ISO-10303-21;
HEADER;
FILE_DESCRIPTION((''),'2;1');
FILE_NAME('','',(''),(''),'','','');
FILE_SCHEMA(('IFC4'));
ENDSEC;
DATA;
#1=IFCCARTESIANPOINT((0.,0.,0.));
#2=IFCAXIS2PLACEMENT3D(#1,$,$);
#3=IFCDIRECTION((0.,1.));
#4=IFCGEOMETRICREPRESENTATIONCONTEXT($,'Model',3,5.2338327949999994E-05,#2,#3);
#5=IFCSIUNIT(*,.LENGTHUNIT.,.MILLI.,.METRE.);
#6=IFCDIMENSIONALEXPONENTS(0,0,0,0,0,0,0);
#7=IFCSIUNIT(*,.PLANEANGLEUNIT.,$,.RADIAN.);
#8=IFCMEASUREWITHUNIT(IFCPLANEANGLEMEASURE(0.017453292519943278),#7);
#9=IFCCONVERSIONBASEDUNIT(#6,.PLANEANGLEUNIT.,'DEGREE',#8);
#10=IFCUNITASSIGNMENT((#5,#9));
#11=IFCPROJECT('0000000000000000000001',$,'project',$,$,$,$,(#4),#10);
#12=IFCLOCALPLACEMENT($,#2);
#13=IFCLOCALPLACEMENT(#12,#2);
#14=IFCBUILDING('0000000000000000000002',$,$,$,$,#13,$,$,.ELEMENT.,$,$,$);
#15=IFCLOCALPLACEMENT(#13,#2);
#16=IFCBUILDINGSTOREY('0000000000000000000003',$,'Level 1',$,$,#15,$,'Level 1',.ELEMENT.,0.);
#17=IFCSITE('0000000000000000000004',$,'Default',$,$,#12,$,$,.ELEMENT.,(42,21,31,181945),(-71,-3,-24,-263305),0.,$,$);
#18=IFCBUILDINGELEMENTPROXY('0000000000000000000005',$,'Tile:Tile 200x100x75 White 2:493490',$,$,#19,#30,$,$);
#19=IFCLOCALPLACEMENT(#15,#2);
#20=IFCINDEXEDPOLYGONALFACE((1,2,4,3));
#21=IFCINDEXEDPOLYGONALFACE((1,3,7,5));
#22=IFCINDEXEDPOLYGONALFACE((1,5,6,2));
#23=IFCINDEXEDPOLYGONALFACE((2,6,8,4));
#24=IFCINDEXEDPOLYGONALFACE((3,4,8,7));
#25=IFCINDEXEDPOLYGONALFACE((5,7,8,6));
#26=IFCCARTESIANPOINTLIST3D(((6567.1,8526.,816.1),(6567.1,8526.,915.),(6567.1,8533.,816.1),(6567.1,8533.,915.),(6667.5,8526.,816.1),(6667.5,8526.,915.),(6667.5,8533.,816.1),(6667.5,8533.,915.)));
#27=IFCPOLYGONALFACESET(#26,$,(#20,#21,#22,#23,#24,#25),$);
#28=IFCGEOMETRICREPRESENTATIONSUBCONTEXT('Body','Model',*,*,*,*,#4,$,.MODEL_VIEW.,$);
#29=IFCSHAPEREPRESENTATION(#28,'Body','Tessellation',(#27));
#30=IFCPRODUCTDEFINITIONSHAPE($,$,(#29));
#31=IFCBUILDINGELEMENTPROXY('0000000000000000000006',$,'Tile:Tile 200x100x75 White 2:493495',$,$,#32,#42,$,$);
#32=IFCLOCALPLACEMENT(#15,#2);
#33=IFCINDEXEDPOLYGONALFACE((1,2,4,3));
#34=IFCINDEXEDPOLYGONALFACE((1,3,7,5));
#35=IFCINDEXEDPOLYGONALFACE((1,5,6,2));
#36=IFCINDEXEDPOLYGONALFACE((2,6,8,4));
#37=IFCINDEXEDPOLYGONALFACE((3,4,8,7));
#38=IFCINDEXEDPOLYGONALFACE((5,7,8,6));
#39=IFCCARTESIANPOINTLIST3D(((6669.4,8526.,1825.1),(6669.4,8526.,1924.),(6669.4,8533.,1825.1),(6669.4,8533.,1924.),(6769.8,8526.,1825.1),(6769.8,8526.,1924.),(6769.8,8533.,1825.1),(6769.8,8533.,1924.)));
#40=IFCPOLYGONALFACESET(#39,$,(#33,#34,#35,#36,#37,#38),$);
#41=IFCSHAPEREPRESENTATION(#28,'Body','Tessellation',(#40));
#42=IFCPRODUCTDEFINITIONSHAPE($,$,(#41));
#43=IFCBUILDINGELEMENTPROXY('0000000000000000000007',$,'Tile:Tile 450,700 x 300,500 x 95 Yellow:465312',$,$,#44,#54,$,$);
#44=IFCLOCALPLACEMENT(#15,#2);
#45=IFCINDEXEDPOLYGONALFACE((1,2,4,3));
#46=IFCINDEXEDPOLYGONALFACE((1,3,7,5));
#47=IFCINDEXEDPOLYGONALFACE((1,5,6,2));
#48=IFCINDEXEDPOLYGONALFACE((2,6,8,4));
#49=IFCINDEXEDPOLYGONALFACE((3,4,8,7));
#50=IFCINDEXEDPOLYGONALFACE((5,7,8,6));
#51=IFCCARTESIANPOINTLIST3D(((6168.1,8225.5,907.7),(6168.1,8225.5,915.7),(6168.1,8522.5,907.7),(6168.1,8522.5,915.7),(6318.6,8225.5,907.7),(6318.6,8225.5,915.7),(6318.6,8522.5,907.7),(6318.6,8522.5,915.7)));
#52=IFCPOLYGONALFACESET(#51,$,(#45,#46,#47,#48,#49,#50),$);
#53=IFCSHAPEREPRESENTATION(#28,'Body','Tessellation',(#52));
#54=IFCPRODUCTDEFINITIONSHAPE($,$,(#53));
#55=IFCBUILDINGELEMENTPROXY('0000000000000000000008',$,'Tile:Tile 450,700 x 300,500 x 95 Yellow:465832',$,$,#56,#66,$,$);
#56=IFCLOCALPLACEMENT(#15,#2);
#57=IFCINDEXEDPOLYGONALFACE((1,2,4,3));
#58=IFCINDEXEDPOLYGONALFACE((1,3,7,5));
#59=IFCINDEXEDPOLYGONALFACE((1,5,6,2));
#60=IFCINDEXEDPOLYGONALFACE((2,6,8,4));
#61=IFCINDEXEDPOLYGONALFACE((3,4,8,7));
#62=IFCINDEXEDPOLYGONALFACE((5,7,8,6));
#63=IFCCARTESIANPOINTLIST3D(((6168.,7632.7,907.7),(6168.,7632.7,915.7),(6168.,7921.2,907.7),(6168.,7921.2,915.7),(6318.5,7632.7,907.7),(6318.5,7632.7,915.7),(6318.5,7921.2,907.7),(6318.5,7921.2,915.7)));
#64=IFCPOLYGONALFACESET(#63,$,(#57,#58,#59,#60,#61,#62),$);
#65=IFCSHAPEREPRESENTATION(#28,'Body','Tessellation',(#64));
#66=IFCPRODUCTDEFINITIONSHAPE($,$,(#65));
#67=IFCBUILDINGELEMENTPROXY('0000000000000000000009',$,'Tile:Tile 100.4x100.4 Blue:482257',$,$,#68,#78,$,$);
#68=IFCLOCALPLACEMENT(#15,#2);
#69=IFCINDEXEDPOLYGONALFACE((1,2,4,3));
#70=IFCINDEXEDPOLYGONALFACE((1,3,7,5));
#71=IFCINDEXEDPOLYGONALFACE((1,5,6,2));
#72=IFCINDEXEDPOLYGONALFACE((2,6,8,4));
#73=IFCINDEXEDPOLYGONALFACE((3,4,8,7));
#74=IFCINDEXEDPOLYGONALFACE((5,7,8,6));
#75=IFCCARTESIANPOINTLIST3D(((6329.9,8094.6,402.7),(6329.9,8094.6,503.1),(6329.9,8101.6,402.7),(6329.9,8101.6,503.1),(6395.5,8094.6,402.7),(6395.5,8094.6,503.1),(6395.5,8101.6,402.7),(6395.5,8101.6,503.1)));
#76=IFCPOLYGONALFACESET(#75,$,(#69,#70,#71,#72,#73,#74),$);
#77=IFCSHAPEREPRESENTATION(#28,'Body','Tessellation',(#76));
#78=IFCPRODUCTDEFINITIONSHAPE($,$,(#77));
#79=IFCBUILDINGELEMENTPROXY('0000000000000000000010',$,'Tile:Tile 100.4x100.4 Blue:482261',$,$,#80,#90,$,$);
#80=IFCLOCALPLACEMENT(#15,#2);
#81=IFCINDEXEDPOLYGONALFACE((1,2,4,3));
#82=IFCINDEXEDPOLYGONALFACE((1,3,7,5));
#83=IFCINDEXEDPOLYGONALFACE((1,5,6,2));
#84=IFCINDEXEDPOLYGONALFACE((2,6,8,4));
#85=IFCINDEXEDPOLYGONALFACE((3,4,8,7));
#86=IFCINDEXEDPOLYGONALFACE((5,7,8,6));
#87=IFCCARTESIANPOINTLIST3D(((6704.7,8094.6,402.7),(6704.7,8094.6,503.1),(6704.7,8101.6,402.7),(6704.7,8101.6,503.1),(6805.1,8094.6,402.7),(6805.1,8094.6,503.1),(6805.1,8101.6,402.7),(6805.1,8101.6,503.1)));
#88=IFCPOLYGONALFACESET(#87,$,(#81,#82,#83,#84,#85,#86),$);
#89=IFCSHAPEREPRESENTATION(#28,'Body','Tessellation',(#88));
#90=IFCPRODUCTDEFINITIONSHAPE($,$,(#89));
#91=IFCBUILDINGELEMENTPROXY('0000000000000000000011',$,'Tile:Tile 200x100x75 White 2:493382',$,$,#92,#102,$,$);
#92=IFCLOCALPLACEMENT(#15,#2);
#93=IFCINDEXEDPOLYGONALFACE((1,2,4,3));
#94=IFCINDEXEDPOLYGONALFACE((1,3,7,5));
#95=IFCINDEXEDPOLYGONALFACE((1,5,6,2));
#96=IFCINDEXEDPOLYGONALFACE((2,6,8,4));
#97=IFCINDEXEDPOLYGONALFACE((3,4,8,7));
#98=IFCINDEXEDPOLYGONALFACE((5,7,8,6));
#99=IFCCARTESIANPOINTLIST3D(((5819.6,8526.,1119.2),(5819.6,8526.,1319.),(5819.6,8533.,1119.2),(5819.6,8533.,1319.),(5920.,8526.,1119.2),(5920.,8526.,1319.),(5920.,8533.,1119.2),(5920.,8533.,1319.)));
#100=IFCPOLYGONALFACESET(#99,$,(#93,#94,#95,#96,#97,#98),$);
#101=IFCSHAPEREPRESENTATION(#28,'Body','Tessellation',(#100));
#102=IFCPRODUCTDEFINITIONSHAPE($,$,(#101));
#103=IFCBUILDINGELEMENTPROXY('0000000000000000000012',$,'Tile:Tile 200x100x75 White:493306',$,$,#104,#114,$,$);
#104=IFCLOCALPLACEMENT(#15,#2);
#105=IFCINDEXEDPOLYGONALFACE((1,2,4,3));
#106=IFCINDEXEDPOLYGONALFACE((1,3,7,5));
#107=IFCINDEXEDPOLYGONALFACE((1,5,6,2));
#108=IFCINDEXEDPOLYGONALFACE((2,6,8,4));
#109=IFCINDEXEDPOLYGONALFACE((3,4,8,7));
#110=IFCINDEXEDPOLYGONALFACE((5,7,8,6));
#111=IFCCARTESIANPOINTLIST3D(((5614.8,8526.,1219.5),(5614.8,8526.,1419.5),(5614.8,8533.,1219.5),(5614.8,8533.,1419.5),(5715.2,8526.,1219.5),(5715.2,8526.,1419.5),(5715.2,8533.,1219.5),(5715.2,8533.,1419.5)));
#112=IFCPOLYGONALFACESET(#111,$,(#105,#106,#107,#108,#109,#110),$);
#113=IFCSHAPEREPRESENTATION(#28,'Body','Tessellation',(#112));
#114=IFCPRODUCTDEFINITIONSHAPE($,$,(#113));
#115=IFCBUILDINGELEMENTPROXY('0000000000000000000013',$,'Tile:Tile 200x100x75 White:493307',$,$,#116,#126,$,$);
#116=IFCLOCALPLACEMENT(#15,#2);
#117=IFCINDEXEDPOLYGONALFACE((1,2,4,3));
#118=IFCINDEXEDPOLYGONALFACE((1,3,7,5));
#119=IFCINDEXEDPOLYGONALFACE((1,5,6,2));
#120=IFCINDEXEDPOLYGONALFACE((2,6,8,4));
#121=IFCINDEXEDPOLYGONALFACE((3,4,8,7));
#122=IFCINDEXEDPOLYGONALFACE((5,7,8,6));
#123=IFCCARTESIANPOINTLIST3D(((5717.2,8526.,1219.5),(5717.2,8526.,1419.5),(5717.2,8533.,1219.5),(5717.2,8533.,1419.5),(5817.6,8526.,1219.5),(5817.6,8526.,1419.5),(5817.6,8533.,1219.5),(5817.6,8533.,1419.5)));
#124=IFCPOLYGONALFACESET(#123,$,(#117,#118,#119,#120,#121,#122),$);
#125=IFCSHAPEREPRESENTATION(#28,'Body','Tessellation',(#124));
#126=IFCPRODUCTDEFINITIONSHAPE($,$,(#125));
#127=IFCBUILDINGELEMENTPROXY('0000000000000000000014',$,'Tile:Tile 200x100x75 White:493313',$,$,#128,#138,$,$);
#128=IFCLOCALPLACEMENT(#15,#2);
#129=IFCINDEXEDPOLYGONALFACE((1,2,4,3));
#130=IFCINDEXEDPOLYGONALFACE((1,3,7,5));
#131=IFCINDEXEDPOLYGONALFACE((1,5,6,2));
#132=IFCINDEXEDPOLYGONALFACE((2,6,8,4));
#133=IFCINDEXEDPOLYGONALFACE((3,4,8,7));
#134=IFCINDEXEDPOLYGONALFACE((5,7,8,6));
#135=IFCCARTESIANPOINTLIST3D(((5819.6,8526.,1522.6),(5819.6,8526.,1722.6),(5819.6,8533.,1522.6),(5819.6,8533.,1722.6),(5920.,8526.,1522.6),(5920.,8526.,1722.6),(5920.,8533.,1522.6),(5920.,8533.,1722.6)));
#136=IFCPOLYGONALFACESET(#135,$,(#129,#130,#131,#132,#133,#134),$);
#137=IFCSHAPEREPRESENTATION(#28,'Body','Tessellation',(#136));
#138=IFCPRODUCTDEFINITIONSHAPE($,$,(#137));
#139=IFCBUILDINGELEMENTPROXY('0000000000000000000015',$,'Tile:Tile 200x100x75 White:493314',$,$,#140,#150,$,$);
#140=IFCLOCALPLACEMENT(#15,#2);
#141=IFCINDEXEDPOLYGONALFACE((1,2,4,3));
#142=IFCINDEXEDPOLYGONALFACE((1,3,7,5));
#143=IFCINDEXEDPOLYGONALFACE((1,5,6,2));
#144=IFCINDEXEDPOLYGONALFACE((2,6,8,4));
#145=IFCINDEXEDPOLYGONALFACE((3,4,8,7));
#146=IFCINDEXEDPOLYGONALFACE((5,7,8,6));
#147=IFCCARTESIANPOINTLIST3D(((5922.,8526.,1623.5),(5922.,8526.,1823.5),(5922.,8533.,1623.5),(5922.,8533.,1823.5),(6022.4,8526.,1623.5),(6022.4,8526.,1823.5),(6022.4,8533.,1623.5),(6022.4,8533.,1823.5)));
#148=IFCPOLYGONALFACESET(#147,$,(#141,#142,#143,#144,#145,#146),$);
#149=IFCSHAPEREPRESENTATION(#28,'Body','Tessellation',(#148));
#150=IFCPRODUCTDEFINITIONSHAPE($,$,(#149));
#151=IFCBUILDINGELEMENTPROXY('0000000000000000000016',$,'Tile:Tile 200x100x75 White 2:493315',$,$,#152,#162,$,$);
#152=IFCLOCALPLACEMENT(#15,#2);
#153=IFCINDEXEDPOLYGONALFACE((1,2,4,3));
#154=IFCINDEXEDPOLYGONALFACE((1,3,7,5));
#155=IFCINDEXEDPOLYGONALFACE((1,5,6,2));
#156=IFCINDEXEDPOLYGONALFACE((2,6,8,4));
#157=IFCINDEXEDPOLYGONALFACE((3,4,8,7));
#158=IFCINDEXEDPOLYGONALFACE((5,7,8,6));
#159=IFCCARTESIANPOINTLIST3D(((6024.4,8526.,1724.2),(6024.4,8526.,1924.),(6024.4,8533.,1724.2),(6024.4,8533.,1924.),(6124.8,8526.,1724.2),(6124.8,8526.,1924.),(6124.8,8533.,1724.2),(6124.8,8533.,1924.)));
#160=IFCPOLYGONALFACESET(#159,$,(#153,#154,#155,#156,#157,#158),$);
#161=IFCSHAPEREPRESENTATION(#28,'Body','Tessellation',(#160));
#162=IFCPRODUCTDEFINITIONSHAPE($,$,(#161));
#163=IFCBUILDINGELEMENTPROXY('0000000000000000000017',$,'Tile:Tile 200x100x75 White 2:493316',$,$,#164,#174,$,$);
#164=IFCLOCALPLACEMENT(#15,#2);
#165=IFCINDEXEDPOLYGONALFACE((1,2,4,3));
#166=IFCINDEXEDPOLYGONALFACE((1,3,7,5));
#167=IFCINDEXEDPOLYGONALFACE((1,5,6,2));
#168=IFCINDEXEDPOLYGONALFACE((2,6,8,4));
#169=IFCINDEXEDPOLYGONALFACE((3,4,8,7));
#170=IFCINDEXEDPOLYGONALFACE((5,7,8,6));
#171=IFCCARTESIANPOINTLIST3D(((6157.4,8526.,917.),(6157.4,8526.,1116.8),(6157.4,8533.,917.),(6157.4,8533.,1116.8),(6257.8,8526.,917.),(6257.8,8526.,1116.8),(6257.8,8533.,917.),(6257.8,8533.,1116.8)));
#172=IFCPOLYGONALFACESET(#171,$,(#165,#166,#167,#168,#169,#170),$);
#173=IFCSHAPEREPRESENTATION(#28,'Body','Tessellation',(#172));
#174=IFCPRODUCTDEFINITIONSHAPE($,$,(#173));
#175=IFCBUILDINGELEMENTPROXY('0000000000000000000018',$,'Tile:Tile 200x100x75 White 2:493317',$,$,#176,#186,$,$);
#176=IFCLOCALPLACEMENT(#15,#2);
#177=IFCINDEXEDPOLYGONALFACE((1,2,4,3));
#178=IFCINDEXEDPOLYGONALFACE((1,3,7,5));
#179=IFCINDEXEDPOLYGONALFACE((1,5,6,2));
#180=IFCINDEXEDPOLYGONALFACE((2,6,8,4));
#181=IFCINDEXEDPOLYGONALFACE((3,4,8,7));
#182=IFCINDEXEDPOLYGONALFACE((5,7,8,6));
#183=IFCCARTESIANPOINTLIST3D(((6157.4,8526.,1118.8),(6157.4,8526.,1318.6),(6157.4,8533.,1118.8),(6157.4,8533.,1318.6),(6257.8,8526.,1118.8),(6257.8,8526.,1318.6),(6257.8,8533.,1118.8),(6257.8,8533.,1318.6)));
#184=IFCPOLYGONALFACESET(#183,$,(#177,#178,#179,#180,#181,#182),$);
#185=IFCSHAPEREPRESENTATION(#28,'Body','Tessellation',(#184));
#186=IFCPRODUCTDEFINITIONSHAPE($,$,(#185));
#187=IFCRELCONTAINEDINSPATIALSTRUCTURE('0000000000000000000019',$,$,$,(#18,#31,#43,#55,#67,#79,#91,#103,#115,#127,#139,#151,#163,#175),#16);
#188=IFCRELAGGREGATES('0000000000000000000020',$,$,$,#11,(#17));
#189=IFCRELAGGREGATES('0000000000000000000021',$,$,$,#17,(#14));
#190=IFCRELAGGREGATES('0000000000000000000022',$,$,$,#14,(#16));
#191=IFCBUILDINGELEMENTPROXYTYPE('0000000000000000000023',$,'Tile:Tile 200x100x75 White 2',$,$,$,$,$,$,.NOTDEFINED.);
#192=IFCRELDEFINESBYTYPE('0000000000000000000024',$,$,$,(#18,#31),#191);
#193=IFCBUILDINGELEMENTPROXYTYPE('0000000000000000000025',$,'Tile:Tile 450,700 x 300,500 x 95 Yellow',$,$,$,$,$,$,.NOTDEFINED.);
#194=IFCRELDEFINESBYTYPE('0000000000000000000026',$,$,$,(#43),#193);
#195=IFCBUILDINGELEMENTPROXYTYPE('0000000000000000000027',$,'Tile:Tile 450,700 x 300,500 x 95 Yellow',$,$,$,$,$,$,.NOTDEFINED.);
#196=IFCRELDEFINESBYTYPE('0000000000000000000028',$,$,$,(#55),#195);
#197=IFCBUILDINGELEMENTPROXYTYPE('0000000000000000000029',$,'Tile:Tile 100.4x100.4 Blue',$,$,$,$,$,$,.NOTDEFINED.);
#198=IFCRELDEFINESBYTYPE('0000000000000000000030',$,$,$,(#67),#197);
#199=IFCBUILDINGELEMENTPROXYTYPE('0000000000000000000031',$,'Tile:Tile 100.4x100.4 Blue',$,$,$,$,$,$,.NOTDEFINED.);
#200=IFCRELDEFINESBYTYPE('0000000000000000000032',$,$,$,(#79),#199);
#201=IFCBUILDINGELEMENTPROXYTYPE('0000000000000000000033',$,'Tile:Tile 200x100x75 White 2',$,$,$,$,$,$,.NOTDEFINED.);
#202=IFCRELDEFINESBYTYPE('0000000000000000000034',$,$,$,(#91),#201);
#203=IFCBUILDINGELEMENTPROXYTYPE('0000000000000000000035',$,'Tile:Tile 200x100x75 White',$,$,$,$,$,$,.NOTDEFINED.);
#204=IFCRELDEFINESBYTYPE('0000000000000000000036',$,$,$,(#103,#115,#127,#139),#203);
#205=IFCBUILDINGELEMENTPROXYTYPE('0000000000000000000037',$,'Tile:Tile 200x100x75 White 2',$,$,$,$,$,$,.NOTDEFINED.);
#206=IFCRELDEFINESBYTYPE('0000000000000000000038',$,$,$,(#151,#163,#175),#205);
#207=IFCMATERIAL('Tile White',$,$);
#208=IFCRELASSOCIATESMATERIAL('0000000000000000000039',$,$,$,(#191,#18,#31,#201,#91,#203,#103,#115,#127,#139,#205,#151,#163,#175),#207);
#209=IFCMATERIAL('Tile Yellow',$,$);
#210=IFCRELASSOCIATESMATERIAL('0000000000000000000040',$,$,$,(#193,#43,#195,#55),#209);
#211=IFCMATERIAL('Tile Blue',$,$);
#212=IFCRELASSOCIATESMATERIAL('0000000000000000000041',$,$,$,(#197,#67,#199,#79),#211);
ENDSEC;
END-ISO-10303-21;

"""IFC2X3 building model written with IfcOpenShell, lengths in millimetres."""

from ifc_helpers import new_model, entity, si_unit, converted_unit, direction, frame, frame_2d, origin, origin_2d_with_axis, place, context, subcontext, project, spatial, rectangle, extrude, source, transform, mapped, material, type_object, type_shapes, element, save


model = new_model("IFC2X3")

# Units and contexts
model_context = context("Model", 3, precision=5.2338327949999994e-05, world=origin(), true_north=direction((0.0, 1.0)))
body_context = subcontext(model_context, "Body", "Model", "MODEL_VIEW")
ifc_project = project(units=[si_unit("LENGTHUNIT", "METRE", prefix="MILLI"), converted_unit("PLANEANGLEUNIT", "DEGREE", entity("IfcPlaneAngleMeasure", 0.017453292519943278), si_unit("PLANEANGLEUNIT", "RADIAN"), dimensions=[0, 0, 0, 0, 0, 0, 0])], contexts=[model_context])

# Site, building, storey
site_placement = place(None, origin())
site = spatial("IfcSite", under=ifc_project, at=site_placement, Name="Default", CompositionType="ELEMENT", RefLatitude=(42, 21, 31, 181945), RefLongitude=(-71, -3, -24, -263305), RefElevation=0.0)
building_placement = place(site_placement, origin())
building = spatial("IfcBuilding", under=site, at=building_placement, CompositionType="ELEMENT")
storey_placement = place(building_placement, origin())
storey = spatial("IfcBuildingStorey", under=building, at=storey_placement, Name="Level 1", LongName="Level 1", CompositionType="ELEMENT", Elevation=0.0)

# Building element proxies
ifc_material_1 = material(Name="Tile White")
building_element_proxy_type_1 = type_object("IfcBuildingElementProxyType", Name="Tile:Tile 200x100x75 White 2", PredefinedType="NOTDEFINED", material=ifc_material_1)
shared_shape_1 = source(origin(), body_context, "Body", "SweptSolid", [
    extrude(rectangle(XDim=98.9, YDim=100.4, at=origin_2d_with_axis()), frame((-50.2, -49.5, 0.0), z_axis=(0.0, 0.0, 1.0), x_axis=(0.0, -1.0, 0.0)), (0.0, 0.0, 1.0), 7.0),
])
type_shapes(building_element_proxy_type_1, [shared_shape_1])
for number, where, z_axis, x_axis, name in (
    (1, (6667.5, 8533.0, 915.0), (0.0, -1.0, 0.0), (1.0, 0.0, 0.0), "Tile:Tile 200x100x75 White 2:493490"),
    (2, (6769.8, 8533.0, 1924.0), (0.0, -1.0, 0.0), (1.0, 0.0, 0.0), "Tile:Tile 200x100x75 White 2:493495"),
):
    element("IfcBuildingElementProxy", number, at=place(storey_placement, frame(where, z_axis=z_axis, x_axis=x_axis)), inside=storey, type_object=building_element_proxy_type_1, material=ifc_material_1, Name=name, context=body_context, shape_type="MappedRepresentation", body=[
        mapped(shared_shape_1, transform((0.0, 0.0, 0.0), scale=1.0)),
    ])
ifc_material_2 = material(Name="Tile Yellow")
building_element_proxy_type_2 = type_object("IfcBuildingElementProxyType", Name="Tile:Tile 450,700 x 300,500 x 95 Yellow", PredefinedType="NOTDEFINED", material=ifc_material_2)
shared_shape_2 = source(origin(), body_context, "Body", "SweptSolid", [
    extrude(rectangle(XDim=150.5, YDim=297.0, at=frame_2d((0.0, 0.0), x_axis=(1.0, 0.0))), frame((-75.2, -148.5, 0.0), z_axis=(0.0, 0.0, 1.0), x_axis=(-1.0, 0.0, 0.0)), (0.0, 0.0, 1.0), 8.0),
])
type_shapes(building_element_proxy_type_2, [shared_shape_2])
proxy_1_placement = place(storey_placement, frame((6318.6, 8522.5, 907.7)))
element("IfcBuildingElementProxy", 3, at=proxy_1_placement, inside=storey, type_object=building_element_proxy_type_2, material=ifc_material_2, Name="Tile:Tile 450,700 x 300,500 x 95 Yellow:465312", context=body_context, shape_type="MappedRepresentation", body=[
    mapped(shared_shape_2, transform((0.0, 0.0, 0.0), scale=1.0)),
])
building_element_proxy_type_3 = type_object("IfcBuildingElementProxyType", Name="Tile:Tile 450,700 x 300,500 x 95 Yellow", PredefinedType="NOTDEFINED", material=ifc_material_2)
shared_shape_3 = source(origin(), body_context, "Body", "SweptSolid", [
    extrude(rectangle(XDim=150.5, YDim=288.5, at=origin_2d_with_axis()), frame((-75.2, -144.3, 0.0), z_axis=(0.0, 0.0, 1.0), x_axis=(-1.0, 0.0, 0.0)), (0.0, 0.0, 1.0), 8.0),
])
type_shapes(building_element_proxy_type_3, [shared_shape_3])
proxy_2_placement = place(storey_placement, frame((6318.5, 7921.2, 907.7)))
element("IfcBuildingElementProxy", 4, at=proxy_2_placement, inside=storey, type_object=building_element_proxy_type_3, material=ifc_material_2, Name="Tile:Tile 450,700 x 300,500 x 95 Yellow:465832", context=body_context, shape_type="MappedRepresentation", body=[
    mapped(shared_shape_3, transform((0.0, 0.0, 0.0), scale=1.0)),
])
ifc_material_3 = material(Name="Tile Blue")
building_element_proxy_type_4 = type_object("IfcBuildingElementProxyType", Name="Tile:Tile 100.4x100.4 Blue", PredefinedType="NOTDEFINED", material=ifc_material_3)
shared_shape_4 = source(origin(), body_context, "Body", "SweptSolid", [
    extrude(rectangle(XDim=65.6, YDim=100.4, at=frame_2d((0.0, 0.0), x_axis=(1.0, 0.0))), frame((-32.8, -50.2, 0.0), z_axis=(0.0, 0.0, 1.0), x_axis=(-1.0, 0.0, 0.0)), (0.0, 0.0, 1.0), 7.0),
])
type_shapes(building_element_proxy_type_4, [shared_shape_4])
proxy_3_placement = place(storey_placement, frame((6329.9, 8101.6, 402.7), z_axis=(0.0, -1.0, 0.0), x_axis=(-1.0, 0.0, 0.0)))
element("IfcBuildingElementProxy", 5, at=proxy_3_placement, inside=storey, type_object=building_element_proxy_type_4, material=ifc_material_3, Name="Tile:Tile 100.4x100.4 Blue:482257", context=body_context, shape_type="MappedRepresentation", body=[
    mapped(shared_shape_4, transform((0.0, 0.0, 0.0), scale=1.0)),
])
building_element_proxy_type_5 = type_object("IfcBuildingElementProxyType", Name="Tile:Tile 100.4x100.4 Blue", PredefinedType="NOTDEFINED", material=ifc_material_3)
shared_shape_5 = source(origin(), body_context, "Body", "SweptSolid", [
    extrude(rectangle(XDim=100.4, YDim=100.4, at=origin_2d_with_axis()), frame((-50.2, -50.2, 0.0), z_axis=(0.0, 0.0, 1.0), x_axis=(0.0, -1.0, 0.0)), (0.0, 0.0, 1.0), 7.0),
])
type_shapes(building_element_proxy_type_5, [shared_shape_5])
proxy_4_placement = place(storey_placement, frame((6704.7, 8101.6, 402.7), z_axis=(0.0, -1.0, 0.0), x_axis=(-1.0, 0.0, 0.0)))
element("IfcBuildingElementProxy", 6, at=proxy_4_placement, inside=storey, type_object=building_element_proxy_type_5, material=ifc_material_3, Name="Tile:Tile 100.4x100.4 Blue:482261", context=body_context, shape_type="MappedRepresentation", body=[
    mapped(shared_shape_5, transform((0.0, 0.0, 0.0), scale=1.0)),
])
building_element_proxy_type_6 = type_object("IfcBuildingElementProxyType", Name="Tile:Tile 200x100x75 White 2", PredefinedType="NOTDEFINED", material=ifc_material_1)
shared_shape_6 = source(origin(), body_context, "Body", "SweptSolid", [
    extrude(rectangle(XDim=199.8, YDim=100.4, at=frame_2d((0.0, 0.0), x_axis=(1.0, 0.0))), frame((-50.2, -99.9, 0.0), z_axis=(0.0, 0.0, 1.0), x_axis=(0.0, -1.0, 0.0)), (0.0, 0.0, 1.0), 7.0),
])
type_shapes(building_element_proxy_type_6, [shared_shape_6])
proxy_5_placement = place(storey_placement, frame((5920.0, 8533.0, 1319.0), z_axis=(0.0, -1.0, 0.0), x_axis=(1.0, 0.0, 0.0)))
element("IfcBuildingElementProxy", 7, at=proxy_5_placement, inside=storey, type_object=building_element_proxy_type_6, material=ifc_material_1, Name="Tile:Tile 200x100x75 White 2:493382", context=body_context, shape_type="MappedRepresentation", body=[
    mapped(shared_shape_6, transform((0.0, 0.0, 0.0), scale=1.0)),
])
building_element_proxy_type_7 = type_object("IfcBuildingElementProxyType", Name="Tile:Tile 200x100x75 White", PredefinedType="NOTDEFINED", material=ifc_material_1)
shared_shape_7 = source(origin(), body_context, "Body", "SweptSolid", [
    extrude(rectangle(XDim=200.0, YDim=100.4, at=frame_2d((0.0, 0.0), x_axis=(1.0, 0.0))), frame((-50.2, -100.0, 0.0), z_axis=(0.0, 0.0, 1.0), x_axis=(0.0, -1.0, 0.0)), (0.0, 0.0, 1.0), 7.0),
])
type_shapes(building_element_proxy_type_7, [shared_shape_7])
for number, where, z_axis, x_axis, name in (
    (8, (5715.2, 8533.0, 1419.5), (0.0, -1.0, 0.0), (1.0, 0.0, 0.0), "Tile:Tile 200x100x75 White:493306"),
    (9, (5817.6, 8533.0, 1419.5), (0.0, -1.0, 0.0), (1.0, 0.0, 0.0), "Tile:Tile 200x100x75 White:493307"),
    (10, (5819.6, 8533.0, 1522.6), (0.0, -1.0, 0.0), (-1.0, 0.0, 0.0), "Tile:Tile 200x100x75 White:493313"),
    (11, (5922.0, 8533.0, 1623.5), (0.0, -1.0, 0.0), (-1.0, 0.0, 0.0), "Tile:Tile 200x100x75 White:493314"),
):
    element("IfcBuildingElementProxy", number, at=place(storey_placement, frame(where, z_axis=z_axis, x_axis=x_axis)), inside=storey, type_object=building_element_proxy_type_7, material=ifc_material_1, Name=name, context=body_context, shape_type="MappedRepresentation", body=[
        mapped(shared_shape_7, transform((0.0, 0.0, 0.0), scale=1.0)),
    ])
building_element_proxy_type_8 = type_object("IfcBuildingElementProxyType", Name="Tile:Tile 200x100x75 White 2", PredefinedType="NOTDEFINED", material=ifc_material_1)
shared_shape_8 = source(origin(), body_context, "Body", "SweptSolid", [
    extrude(rectangle(XDim=199.8, YDim=100.4, at=frame_2d((0.0, 0.0), x_axis=(1.0, 0.0))), frame((-50.2, -99.9, 0.0), z_axis=(0.0, 0.0, 1.0), x_axis=(0.0, -1.0, 0.0)), (0.0, 0.0, 1.0), 7.0),
])
type_shapes(building_element_proxy_type_8, [shared_shape_8])
for number, where, z_axis, x_axis, name in (
    (12, (6024.4, 8533.0, 1724.2), (0.0, -1.0, 0.0), (-1.0, 0.0, 0.0), "Tile:Tile 200x100x75 White 2:493315"),
    (13, (6257.8, 8533.0, 1116.8), (0.0, -1.0, 0.0), (1.0, 0.0, 0.0), "Tile:Tile 200x100x75 White 2:493316"),
    (14, (6257.8, 8533.0, 1318.6), (0.0, -1.0, 0.0), (1.0, 0.0, 0.0), "Tile:Tile 200x100x75 White 2:493317"),
):
    element("IfcBuildingElementProxy", number, at=place(storey_placement, frame(where, z_axis=z_axis, x_axis=x_axis)), inside=storey, type_object=building_element_proxy_type_8, material=ifc_material_1, Name=name, context=body_context, shape_type="MappedRepresentation", body=[
        mapped(shared_shape_8, transform((0.0, 0.0, 0.0), scale=1.0)),
    ])

save(model, "model.ifc")
